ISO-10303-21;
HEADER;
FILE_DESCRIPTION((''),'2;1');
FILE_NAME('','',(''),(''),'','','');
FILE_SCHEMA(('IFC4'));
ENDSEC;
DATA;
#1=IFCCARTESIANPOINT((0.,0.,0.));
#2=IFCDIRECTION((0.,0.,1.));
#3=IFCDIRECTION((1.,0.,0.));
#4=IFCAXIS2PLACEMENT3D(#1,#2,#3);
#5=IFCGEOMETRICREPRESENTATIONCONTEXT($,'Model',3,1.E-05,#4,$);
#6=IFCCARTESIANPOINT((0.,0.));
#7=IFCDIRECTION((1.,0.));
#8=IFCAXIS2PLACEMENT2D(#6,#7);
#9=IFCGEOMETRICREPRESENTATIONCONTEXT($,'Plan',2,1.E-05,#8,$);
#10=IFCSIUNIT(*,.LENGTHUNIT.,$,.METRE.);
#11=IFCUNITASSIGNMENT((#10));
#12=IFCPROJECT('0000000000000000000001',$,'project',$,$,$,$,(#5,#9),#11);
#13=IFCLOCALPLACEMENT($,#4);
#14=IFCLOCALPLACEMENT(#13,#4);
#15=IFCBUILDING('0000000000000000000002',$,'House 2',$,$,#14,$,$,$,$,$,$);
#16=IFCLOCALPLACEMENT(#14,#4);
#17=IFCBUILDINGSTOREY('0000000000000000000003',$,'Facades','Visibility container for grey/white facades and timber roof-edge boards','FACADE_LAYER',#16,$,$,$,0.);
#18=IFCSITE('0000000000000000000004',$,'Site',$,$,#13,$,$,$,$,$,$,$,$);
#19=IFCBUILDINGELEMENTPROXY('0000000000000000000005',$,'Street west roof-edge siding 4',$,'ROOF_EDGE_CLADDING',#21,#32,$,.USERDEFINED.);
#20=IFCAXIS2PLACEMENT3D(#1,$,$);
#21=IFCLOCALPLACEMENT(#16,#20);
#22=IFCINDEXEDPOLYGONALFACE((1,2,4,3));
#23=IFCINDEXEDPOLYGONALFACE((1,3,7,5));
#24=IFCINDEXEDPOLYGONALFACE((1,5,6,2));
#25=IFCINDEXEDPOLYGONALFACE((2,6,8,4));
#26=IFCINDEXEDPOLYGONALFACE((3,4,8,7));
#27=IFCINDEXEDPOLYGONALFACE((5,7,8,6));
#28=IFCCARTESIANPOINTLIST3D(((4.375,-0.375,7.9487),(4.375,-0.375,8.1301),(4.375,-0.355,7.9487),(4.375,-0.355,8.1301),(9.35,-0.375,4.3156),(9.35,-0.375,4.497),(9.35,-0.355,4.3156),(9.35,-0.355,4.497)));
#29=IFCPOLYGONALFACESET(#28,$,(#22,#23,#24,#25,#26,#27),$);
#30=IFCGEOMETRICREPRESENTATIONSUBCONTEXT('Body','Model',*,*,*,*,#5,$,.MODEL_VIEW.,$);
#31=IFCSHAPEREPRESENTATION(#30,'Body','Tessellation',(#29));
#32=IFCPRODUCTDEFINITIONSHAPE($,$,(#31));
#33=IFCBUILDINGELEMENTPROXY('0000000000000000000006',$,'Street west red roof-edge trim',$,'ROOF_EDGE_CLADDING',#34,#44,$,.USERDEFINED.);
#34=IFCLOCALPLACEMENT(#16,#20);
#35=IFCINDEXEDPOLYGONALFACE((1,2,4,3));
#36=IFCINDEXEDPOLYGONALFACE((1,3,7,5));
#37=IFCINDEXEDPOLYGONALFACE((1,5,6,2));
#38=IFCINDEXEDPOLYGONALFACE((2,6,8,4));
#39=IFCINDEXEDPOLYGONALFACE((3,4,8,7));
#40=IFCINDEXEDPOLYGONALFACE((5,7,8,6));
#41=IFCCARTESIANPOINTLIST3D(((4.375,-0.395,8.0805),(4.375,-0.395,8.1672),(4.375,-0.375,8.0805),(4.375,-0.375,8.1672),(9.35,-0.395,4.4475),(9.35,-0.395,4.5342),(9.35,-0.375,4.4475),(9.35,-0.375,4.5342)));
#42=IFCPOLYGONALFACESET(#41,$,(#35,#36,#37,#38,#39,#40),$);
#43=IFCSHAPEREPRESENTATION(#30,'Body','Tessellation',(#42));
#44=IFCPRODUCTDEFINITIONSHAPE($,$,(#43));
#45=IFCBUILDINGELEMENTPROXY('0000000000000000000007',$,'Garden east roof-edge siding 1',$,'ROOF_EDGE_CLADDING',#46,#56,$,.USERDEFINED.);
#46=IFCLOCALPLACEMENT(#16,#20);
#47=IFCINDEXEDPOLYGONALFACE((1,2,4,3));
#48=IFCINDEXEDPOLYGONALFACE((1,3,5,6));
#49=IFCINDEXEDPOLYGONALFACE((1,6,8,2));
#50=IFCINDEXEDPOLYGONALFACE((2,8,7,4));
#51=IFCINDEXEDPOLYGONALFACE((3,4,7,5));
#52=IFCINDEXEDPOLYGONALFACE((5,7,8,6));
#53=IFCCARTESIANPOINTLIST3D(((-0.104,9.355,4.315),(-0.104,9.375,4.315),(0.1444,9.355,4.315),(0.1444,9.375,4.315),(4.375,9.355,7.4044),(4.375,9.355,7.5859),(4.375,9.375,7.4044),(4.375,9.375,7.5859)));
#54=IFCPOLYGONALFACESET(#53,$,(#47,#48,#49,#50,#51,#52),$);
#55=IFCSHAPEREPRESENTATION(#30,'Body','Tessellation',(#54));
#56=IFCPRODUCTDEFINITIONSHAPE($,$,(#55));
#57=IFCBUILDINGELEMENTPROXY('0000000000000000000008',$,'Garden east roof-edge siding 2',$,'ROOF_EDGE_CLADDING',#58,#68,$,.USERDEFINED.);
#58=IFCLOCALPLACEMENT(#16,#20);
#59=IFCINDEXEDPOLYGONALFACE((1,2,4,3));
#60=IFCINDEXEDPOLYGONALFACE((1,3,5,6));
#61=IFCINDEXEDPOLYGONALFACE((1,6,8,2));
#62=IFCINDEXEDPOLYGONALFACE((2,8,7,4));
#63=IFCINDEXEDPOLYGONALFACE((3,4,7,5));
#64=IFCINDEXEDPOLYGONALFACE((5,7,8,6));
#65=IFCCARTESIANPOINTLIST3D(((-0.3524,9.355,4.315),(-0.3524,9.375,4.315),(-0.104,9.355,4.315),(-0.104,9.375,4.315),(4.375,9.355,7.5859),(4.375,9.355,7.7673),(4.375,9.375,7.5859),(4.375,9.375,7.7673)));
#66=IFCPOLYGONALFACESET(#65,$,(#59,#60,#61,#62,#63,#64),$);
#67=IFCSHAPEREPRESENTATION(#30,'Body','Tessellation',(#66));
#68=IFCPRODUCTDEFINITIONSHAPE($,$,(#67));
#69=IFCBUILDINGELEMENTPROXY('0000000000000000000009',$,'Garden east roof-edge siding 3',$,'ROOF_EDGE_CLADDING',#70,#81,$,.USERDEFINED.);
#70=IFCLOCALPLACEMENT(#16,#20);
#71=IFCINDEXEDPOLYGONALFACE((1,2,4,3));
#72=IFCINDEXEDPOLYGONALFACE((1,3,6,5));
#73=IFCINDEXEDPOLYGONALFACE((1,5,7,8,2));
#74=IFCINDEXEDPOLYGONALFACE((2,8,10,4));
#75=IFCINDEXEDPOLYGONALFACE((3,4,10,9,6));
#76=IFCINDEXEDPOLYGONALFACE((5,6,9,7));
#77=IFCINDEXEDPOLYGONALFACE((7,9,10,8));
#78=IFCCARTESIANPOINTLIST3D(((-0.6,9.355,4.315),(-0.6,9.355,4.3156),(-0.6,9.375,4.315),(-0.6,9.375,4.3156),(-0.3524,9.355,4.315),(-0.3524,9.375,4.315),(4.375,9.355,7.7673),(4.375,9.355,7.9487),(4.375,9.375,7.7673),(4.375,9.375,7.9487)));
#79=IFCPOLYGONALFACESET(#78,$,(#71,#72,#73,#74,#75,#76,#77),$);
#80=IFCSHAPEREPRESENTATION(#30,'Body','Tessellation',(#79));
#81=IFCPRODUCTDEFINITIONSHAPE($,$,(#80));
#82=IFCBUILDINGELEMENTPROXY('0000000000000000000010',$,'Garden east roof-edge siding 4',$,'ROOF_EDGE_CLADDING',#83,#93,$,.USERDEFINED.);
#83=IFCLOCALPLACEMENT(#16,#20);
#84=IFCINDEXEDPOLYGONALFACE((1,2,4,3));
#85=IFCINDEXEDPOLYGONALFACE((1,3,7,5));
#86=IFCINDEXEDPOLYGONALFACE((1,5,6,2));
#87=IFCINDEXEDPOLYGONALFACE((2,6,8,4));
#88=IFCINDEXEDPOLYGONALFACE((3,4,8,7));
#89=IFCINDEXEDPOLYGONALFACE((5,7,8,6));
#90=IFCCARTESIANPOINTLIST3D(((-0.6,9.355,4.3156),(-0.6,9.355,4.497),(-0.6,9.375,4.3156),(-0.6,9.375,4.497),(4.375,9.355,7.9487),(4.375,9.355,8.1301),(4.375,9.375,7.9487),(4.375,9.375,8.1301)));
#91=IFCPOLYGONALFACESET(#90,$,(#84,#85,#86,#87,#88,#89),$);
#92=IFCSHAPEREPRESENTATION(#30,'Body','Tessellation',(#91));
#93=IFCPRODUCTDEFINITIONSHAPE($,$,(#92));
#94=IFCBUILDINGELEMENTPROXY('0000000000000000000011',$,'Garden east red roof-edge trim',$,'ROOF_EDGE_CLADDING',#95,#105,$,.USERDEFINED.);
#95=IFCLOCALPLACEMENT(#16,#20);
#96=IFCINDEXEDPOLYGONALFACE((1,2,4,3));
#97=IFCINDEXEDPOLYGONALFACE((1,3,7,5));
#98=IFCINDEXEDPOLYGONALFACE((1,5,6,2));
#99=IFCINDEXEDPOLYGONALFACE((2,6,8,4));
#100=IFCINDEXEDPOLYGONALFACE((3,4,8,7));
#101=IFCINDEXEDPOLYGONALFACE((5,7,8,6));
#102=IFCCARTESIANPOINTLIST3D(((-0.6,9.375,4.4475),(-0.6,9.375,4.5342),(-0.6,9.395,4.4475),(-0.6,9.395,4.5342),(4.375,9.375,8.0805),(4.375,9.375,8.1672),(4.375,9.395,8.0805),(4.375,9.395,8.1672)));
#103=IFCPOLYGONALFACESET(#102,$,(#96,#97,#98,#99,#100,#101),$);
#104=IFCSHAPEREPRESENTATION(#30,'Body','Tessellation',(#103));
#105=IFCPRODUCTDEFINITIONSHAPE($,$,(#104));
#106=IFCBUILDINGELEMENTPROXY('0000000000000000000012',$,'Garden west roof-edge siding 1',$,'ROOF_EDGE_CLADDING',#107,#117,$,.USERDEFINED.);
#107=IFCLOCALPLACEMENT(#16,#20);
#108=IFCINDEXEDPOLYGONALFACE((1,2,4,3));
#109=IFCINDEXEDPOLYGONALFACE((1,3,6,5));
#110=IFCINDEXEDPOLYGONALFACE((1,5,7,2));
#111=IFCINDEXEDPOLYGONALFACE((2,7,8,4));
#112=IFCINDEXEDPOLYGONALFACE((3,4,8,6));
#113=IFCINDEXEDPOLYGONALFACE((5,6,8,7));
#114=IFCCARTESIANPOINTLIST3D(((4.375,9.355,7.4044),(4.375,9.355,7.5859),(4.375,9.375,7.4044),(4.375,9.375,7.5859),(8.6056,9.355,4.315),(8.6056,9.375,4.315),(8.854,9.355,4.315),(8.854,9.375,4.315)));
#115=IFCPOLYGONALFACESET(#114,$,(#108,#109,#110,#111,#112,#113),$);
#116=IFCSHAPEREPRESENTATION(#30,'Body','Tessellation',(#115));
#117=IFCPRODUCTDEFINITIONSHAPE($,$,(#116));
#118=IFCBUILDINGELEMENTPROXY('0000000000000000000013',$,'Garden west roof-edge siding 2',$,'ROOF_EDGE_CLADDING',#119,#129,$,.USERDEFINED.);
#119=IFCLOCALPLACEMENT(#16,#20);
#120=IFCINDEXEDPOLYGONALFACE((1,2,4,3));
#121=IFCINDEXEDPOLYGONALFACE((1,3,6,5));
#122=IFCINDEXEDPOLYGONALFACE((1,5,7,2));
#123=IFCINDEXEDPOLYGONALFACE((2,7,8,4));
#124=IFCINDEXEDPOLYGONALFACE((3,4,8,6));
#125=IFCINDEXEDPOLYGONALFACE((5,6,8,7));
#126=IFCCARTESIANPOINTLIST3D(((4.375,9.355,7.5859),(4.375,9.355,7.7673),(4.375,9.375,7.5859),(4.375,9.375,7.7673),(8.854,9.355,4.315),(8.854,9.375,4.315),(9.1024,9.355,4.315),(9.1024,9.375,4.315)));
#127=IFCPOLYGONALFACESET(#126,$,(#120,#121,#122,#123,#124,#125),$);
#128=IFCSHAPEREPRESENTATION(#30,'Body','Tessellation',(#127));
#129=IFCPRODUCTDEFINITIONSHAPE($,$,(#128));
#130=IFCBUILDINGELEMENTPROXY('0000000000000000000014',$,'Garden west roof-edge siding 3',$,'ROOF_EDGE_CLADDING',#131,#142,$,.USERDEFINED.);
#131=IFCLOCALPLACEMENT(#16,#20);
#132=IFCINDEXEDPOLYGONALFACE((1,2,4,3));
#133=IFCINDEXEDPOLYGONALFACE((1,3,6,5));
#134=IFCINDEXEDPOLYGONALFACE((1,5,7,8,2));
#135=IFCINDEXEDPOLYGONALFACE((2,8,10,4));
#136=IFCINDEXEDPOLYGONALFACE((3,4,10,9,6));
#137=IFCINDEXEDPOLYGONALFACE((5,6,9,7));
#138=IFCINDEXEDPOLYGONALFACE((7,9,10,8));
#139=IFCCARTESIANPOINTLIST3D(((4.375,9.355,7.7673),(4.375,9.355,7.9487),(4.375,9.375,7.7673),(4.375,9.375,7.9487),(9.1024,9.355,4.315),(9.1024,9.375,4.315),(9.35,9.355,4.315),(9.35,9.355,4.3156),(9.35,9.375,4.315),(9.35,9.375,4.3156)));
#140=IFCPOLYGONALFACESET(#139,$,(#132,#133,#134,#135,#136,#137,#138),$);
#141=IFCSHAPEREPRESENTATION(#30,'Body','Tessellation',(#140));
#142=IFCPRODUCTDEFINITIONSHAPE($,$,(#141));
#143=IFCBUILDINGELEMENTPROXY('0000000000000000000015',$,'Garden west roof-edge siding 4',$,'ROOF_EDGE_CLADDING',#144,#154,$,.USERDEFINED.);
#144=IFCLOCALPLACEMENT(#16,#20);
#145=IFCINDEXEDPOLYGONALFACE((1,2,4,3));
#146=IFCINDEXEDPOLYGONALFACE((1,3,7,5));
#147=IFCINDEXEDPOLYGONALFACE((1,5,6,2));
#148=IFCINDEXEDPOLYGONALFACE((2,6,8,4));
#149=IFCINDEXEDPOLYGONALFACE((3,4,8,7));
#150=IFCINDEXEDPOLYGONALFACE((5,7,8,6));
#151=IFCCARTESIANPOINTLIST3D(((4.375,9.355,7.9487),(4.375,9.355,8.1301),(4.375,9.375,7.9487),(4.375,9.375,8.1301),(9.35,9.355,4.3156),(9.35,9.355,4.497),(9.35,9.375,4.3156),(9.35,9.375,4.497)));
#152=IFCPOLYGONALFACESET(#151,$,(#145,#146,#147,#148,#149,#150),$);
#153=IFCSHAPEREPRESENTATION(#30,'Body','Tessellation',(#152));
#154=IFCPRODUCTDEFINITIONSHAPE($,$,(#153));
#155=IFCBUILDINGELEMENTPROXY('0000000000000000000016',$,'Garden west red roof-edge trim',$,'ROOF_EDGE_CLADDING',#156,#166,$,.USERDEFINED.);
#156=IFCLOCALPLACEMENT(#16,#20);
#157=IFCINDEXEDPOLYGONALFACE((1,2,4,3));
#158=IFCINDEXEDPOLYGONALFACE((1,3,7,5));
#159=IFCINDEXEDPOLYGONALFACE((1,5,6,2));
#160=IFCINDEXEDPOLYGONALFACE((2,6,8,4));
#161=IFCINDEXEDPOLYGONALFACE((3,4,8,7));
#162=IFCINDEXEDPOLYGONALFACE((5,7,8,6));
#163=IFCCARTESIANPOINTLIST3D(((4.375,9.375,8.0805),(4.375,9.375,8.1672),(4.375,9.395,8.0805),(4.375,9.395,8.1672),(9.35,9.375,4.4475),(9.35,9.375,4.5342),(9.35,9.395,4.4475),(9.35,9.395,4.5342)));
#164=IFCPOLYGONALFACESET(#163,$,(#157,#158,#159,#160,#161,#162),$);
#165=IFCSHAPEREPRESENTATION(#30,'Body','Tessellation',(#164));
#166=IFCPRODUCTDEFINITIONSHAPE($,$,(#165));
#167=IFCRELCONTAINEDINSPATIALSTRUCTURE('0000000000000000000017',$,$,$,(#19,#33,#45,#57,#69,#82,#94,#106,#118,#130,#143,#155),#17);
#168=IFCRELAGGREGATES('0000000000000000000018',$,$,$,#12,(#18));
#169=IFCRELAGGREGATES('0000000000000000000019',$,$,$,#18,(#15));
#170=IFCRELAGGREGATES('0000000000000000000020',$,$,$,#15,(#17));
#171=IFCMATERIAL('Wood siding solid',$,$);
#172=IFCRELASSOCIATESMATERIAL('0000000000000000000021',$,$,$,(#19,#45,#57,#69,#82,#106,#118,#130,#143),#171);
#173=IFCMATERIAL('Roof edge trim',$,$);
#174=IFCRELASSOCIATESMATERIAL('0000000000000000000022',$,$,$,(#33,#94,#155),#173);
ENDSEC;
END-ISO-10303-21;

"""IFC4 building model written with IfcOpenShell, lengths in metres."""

from ifc_helpers import new_model, si_unit, frame, origin_with_axes, origin_2d_with_axis, place, context, subcontext, project, spatial, line, indexed_curve, outline, extrude, material, element, save


model = new_model("IFC4")

# Units and contexts
model_context = context("Model", 3, precision=1e-05, world=origin_with_axes())
plan_context = context("Plan", 2, precision=1e-05, world=origin_2d_with_axis())
body_context = subcontext(model_context, "Body", "Model", "MODEL_VIEW")
ifc_project = project(units=[si_unit("LENGTHUNIT", "METRE")], contexts=[model_context, plan_context])

# Site, building, storey
site_placement = place(None, origin_with_axes())
site = spatial("IfcSite", under=ifc_project, at=site_placement, Name="Site")
building_placement = place(site_placement, origin_with_axes())
building = spatial("IfcBuilding", under=site, at=building_placement, Name="House 2")
storey_placement = place(building_placement, origin_with_axes())
storey = spatial("IfcBuildingStorey", under=building, at=storey_placement, Name="Facades", Description="Visibility container for grey/white facades and timber roof-edge boards", ObjectType="FACADE_LAYER", Elevation=0.0)

# Building element proxies
ifc_material_1 = material(Name="Wood siding solid")
ifc_material_2 = material(Name="Roof edge trim")
proxy_1_placement = place(storey_placement, frame((4.375, -0.375, 7.9487), z_axis=(0.0, 1.0, 0.0), x_axis=(0.0, 0.0, 1.0)))
element("IfcBuildingElementProxy", 1, at=proxy_1_placement, inside=storey, material=ifc_material_1, Name="Street west roof-edge siding 4", ObjectType="ROOF_EDGE_CLADDING", PredefinedType="USERDEFINED", context=body_context, shape_type="SweptSolid", body=[
    extrude(outline(indexed_curve([(0.0, 0.0), (0.1814, 0.0), (-3.4517, 4.975), (-3.6331, 4.975)], segments=[line(1, 2, 3, 4, 1)])), origin_with_axes(), (0.0, 0.0, 1.0), 0.02),
])
proxy_2_placement = place(storey_placement, frame((9.35, -0.375, 4.4475), z_axis=(0.0, -1.0, 0.0), x_axis=(0.0, 0.0, 1.0)))
element("IfcBuildingElementProxy", 2, at=proxy_2_placement, inside=storey, material=ifc_material_2, Name="Street west red roof-edge trim", ObjectType="ROOF_EDGE_CLADDING", PredefinedType="USERDEFINED", context=body_context, shape_type="SweptSolid", body=[
    extrude(outline(indexed_curve([(0.0, 0.0), (0.0867, 0.0), (3.7197, 4.975), (3.6331, 4.975)], segments=[line(1, 2, 3, 4, 1)])), origin_with_axes(), (0.0, 0.0, 1.0), 0.02),
])
proxy_3_placement = place(storey_placement, frame((4.375, 9.375, 7.4044), z_axis=(0.0, -1.0, 0.0), x_axis=(0.0, 0.0, 1.0)))
element("IfcBuildingElementProxy", 3, at=proxy_3_placement, inside=storey, material=ifc_material_1, Name="Garden east roof-edge siding 1", ObjectType="ROOF_EDGE_CLADDING", PredefinedType="USERDEFINED", context=body_context, shape_type="SweptSolid", body=[
    extrude(outline(indexed_curve([(0.0, 0.0), (0.1814, 0.0), (-3.0894, 4.479), (-3.0894, 4.2306)], segments=[line(1, 2, 3, 4, 1)])), origin_with_axes(), (0.0, 0.0, 1.0), 0.02),
])
proxy_4_placement = place(storey_placement, frame((4.375, 9.375, 7.5859), z_axis=(0.0, -1.0, 0.0), x_axis=(0.0, 0.0, 1.0)))
element("IfcBuildingElementProxy", 4, at=proxy_4_placement, inside=storey, material=ifc_material_1, Name="Garden east roof-edge siding 2", ObjectType="ROOF_EDGE_CLADDING", PredefinedType="USERDEFINED", context=body_context, shape_type="SweptSolid", body=[
    extrude(outline(indexed_curve([(0.0, 0.0), (0.1814, 0.0), (-3.2709, 4.7274), (-3.2709, 4.479)], segments=[line(1, 2, 3, 4, 1)])), origin_with_axes(), (0.0, 0.0, 1.0), 0.02),
])
proxy_5_placement = place(storey_placement, frame((4.375, 9.375, 7.7673), z_axis=(0.0, -1.0, 0.0), x_axis=(0.0, 0.0, 1.0)))
element("IfcBuildingElementProxy", 5, at=proxy_5_placement, inside=storey, material=ifc_material_1, Name="Garden east roof-edge siding 3", ObjectType="ROOF_EDGE_CLADDING", PredefinedType="USERDEFINED", context=body_context, shape_type="SweptSolid", body=[
    extrude(outline(indexed_curve([(0.0, 0.0), (0.1814, 0.0), (-3.4517, 4.975), (-3.4523, 4.975), (-3.4523, 4.7274)], segments=[line(1, 2, 3, 4, 5, 1)])), origin_with_axes(), (0.0, 0.0, 1.0), 0.02),
])
proxy_6_placement = place(storey_placement, frame((4.375, 9.375, 7.9487), z_axis=(0.0, -1.0, 0.0), x_axis=(0.0, 0.0, 1.0)))
element("IfcBuildingElementProxy", 6, at=proxy_6_placement, inside=storey, material=ifc_material_1, Name="Garden east roof-edge siding 4", ObjectType="ROOF_EDGE_CLADDING", PredefinedType="USERDEFINED", context=body_context, shape_type="SweptSolid", body=[
    extrude(outline(indexed_curve([(0.0, 0.0), (0.1814, 0.0), (-3.4517, 4.975), (-3.6331, 4.975)], segments=[line(1, 2, 3, 4, 1)])), origin_with_axes(), (0.0, 0.0, 1.0), 0.02),
])
proxy_7_placement = place(storey_placement, frame((-0.6, 9.375, 4.4475), z_axis=(0.0, 1.0, 0.0), x_axis=(0.0, 0.0, 1.0)))
element("IfcBuildingElementProxy", 7, at=proxy_7_placement, inside=storey, material=ifc_material_2, Name="Garden east red roof-edge trim", ObjectType="ROOF_EDGE_CLADDING", PredefinedType="USERDEFINED", context=body_context, shape_type="SweptSolid", body=[
    extrude(outline(indexed_curve([(0.0, 0.0), (0.0867, 0.0), (3.7197, 4.975), (3.6331, 4.975)], segments=[line(1, 2, 3, 4, 1)])), origin_with_axes(), (0.0, 0.0, 1.0), 0.02),
])
proxy_8_placement = place(storey_placement, frame((8.6056, 9.375, 4.315), z_axis=(0.0, -1.0, 0.0), x_axis=(1.0, 0.0, 0.0)))
element("IfcBuildingElementProxy", 8, at=proxy_8_placement, inside=storey, material=ifc_material_1, Name="Garden west roof-edge siding 1", ObjectType="ROOF_EDGE_CLADDING", PredefinedType="USERDEFINED", context=body_context, shape_type="SweptSolid", body=[
    extrude(outline(indexed_curve([(0.0, 0.0), (0.2484, 0.0), (-4.2306, 3.2709), (-4.2306, 3.0894)], segments=[line(1, 2, 3, 4, 1)])), origin_with_axes(), (0.0, 0.0, 1.0), 0.02),
])
proxy_9_placement = place(storey_placement, frame((8.854, 9.375, 4.315), z_axis=(0.0, -1.0, 0.0), x_axis=(1.0, 0.0, 0.0)))
element("IfcBuildingElementProxy", 9, at=proxy_9_placement, inside=storey, material=ifc_material_1, Name="Garden west roof-edge siding 2", ObjectType="ROOF_EDGE_CLADDING", PredefinedType="USERDEFINED", context=body_context, shape_type="SweptSolid", body=[
    extrude(outline(indexed_curve([(0.0, 0.0), (0.2484, 0.0), (-4.479, 3.4523), (-4.479, 3.2709)], segments=[line(1, 2, 3, 4, 1)])), origin_with_axes(), (0.0, 0.0, 1.0), 0.02),
])
proxy_10_placement = place(storey_placement, frame((9.1024, 9.375, 4.315), z_axis=(0.0, -1.0, 0.0), x_axis=(1.0, 0.0, 0.0)))
element("IfcBuildingElementProxy", 10, at=proxy_10_placement, inside=storey, material=ifc_material_1, Name="Garden west roof-edge siding 3", ObjectType="ROOF_EDGE_CLADDING", PredefinedType="USERDEFINED", context=body_context, shape_type="SweptSolid", body=[
    extrude(outline(indexed_curve([(0.0, 0.0), (0.2476, 0.0), (0.2476, 0.0006), (-4.7274, 3.6337), (-4.7274, 3.4523)], segments=[line(1, 2, 3, 4, 5, 1)])), origin_with_axes(), (0.0, 0.0, 1.0), 0.02),
])
proxy_11_placement = place(storey_placement, frame((9.35, 9.375, 4.3156), z_axis=(0.0, -1.0, 0.0), x_axis=(0.0, 0.0, 1.0)))
element("IfcBuildingElementProxy", 11, at=proxy_11_placement, inside=storey, material=ifc_material_1, Name="Garden west roof-edge siding 4", ObjectType="ROOF_EDGE_CLADDING", PredefinedType="USERDEFINED", context=body_context, shape_type="SweptSolid", body=[
    extrude(outline(indexed_curve([(0.0, 0.0), (0.1814, 0.0), (3.8145, 4.975), (3.6331, 4.975)], segments=[line(1, 2, 3, 4, 1)])), origin_with_axes(), (0.0, 0.0, 1.0), 0.02),
])
proxy_12_placement = place(storey_placement, frame((4.375, 9.375, 8.0805), z_axis=(0.0, 1.0, 0.0), x_axis=(0.0, 0.0, 1.0)))
element("IfcBuildingElementProxy", 12, at=proxy_12_placement, inside=storey, material=ifc_material_2, Name="Garden west red roof-edge trim", ObjectType="ROOF_EDGE_CLADDING", PredefinedType="USERDEFINED", context=body_context, shape_type="SweptSolid", body=[
    extrude(outline(indexed_curve([(0.0, 0.0), (0.0867, 0.0), (-3.5464, 4.975), (-3.6331, 4.975)], segments=[line(1, 2, 3, 4, 1)])), origin_with_axes(), (0.0, 0.0, 1.0), 0.02),
])

save(model, "model.ifc")
